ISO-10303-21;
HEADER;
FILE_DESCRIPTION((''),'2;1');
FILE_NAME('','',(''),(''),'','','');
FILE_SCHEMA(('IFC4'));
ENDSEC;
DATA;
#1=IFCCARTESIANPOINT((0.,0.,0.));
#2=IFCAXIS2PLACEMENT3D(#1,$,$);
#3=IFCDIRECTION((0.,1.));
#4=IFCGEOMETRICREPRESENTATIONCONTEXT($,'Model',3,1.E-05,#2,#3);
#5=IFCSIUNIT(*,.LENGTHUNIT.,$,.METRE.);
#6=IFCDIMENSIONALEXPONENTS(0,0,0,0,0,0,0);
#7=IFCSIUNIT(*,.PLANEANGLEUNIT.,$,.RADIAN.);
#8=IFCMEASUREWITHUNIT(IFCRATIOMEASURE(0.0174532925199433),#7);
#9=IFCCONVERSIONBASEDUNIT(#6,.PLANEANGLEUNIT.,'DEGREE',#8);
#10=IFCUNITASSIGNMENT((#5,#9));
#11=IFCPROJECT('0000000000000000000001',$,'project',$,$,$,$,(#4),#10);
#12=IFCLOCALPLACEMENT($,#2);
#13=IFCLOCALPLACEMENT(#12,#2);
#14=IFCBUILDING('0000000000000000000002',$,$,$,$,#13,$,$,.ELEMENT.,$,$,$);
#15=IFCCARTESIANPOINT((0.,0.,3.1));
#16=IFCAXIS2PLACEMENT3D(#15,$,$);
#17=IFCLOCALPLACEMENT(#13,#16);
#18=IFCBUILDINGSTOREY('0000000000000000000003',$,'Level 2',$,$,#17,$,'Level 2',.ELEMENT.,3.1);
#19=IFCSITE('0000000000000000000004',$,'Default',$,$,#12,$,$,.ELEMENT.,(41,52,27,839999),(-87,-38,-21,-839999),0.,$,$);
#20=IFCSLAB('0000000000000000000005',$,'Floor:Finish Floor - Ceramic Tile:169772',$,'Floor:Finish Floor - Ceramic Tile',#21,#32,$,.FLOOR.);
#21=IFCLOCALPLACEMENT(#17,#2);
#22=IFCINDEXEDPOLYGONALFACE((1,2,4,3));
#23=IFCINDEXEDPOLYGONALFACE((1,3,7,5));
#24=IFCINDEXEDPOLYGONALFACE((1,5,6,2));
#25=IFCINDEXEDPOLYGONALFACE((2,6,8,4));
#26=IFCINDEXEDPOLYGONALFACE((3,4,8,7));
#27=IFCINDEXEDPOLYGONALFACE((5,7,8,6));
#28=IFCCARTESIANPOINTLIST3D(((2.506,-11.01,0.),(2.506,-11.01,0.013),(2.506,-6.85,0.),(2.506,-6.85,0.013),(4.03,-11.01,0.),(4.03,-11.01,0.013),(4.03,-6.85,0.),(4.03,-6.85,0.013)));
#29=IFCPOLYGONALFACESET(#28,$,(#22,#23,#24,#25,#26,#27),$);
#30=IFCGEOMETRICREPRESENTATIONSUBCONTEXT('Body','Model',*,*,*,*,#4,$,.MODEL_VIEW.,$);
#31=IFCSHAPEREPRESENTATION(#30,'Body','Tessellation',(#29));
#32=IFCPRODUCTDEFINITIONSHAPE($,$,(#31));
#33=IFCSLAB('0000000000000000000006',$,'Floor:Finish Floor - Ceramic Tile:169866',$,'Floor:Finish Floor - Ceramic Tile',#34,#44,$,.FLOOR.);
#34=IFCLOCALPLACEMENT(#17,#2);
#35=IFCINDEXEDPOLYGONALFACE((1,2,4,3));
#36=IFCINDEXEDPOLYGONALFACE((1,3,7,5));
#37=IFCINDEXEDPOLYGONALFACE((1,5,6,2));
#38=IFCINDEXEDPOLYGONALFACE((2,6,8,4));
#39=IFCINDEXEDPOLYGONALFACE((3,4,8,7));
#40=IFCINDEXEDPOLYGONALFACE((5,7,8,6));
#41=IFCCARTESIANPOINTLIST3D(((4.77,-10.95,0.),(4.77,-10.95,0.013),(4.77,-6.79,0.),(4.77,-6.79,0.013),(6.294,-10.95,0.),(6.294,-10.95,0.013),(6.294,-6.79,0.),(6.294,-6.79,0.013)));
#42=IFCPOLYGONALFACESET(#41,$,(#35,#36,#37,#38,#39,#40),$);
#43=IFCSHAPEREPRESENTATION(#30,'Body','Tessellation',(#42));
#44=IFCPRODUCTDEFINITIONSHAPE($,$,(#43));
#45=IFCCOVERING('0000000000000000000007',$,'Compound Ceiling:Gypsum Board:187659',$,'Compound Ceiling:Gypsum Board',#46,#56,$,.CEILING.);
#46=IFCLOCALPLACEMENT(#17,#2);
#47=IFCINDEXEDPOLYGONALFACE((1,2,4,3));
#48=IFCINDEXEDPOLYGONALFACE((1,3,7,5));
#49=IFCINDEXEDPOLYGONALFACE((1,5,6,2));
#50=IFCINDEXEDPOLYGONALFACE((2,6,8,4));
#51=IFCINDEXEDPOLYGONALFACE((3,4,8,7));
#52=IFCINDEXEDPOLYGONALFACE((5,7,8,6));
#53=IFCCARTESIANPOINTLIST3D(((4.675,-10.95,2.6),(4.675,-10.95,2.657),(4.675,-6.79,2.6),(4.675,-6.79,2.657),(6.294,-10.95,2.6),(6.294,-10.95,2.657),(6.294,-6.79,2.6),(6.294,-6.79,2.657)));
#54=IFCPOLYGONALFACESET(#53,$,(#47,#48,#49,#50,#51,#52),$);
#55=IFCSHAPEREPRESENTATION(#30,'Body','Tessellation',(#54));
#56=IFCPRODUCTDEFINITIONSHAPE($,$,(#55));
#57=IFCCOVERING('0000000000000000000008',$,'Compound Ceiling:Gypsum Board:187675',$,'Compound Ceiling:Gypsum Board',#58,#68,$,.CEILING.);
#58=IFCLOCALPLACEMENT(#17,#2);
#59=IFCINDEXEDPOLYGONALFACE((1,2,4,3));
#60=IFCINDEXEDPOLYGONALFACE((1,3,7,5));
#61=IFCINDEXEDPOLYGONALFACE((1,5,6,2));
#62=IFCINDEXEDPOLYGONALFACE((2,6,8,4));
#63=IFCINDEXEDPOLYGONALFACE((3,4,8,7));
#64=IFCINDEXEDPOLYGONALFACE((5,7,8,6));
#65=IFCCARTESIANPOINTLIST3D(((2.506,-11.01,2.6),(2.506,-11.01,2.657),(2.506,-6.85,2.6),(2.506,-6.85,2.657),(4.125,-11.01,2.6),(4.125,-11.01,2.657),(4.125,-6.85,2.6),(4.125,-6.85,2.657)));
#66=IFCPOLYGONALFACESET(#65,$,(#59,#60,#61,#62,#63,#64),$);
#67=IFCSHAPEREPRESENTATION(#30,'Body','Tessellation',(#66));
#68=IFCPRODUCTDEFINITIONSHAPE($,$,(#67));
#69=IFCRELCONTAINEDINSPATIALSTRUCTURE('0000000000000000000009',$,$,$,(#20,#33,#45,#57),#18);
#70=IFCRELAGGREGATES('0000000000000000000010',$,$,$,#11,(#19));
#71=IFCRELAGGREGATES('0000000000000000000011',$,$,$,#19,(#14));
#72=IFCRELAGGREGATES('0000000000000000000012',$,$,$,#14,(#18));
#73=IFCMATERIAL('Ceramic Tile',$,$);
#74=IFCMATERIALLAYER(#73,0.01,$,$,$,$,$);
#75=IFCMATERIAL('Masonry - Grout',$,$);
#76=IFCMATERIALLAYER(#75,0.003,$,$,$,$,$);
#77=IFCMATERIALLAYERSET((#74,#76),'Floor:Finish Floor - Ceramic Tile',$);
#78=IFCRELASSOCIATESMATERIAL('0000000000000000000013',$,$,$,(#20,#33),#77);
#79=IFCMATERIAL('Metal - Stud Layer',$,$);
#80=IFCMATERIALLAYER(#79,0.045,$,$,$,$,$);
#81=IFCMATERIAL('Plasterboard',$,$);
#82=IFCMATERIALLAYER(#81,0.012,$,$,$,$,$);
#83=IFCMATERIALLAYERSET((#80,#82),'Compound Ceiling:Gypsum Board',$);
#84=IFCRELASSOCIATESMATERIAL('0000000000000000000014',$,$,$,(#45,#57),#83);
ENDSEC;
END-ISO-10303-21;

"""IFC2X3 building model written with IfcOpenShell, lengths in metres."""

from ifc_helpers import new_model, entity, si_unit, converted_unit, direction, frame, frame_2d, origin, place, context, subcontext, project, spatial, rectangle, extrude, material, layer, layer_set, layer_usage, element, save


model = new_model("IFC2X3")

# Units and contexts
model_context = context("Model", 3, precision=1e-05, world=origin(), true_north=direction((0.0, 1.0)))
body_context = subcontext(model_context, "Body", "Model", "MODEL_VIEW")
ifc_project = project(units=[si_unit("LENGTHUNIT", "METRE"), converted_unit("PLANEANGLEUNIT", "DEGREE", entity("IfcRatioMeasure", 0.0174532925199433), si_unit("PLANEANGLEUNIT", "RADIAN"), dimensions=[0, 0, 0, 0, 0, 0, 0])], contexts=[model_context])

# Site, building, storey
site_placement = place(None, origin())
site = spatial("IfcSite", under=ifc_project, at=site_placement, Name="Default", CompositionType="ELEMENT", RefLatitude=(41, 52, 27, 839999), RefLongitude=(-87, -38, -21, -839999), RefElevation=0.0)
building_placement = place(site_placement, origin())
building = spatial("IfcBuilding", under=site, at=building_placement, CompositionType="ELEMENT")
storey_placement = place(building_placement, frame((0.0, 0.0, 3.1)))
storey = spatial("IfcBuildingStorey", under=building, at=storey_placement, Name="Level 2", LongName="Level 2", CompositionType="ELEMENT", Elevation=3.1)

# Slabs
ifc_material_1 = material(Name="Ceramic Tile")
ifc_layer_1 = layer(ifc_material_1, 0.01)
ifc_material_2 = material(Name="Masonry - Grout")
ifc_layer_2 = layer(ifc_material_2, 0.003)
ifc_layer_set_1 = layer_set([ifc_layer_1, ifc_layer_2], Name="Floor:Finish Floor - Ceramic Tile")
ifc_layer_usage_1 = layer_usage(ifc_layer_set_1, "AXIS3", "POSITIVE", 0.0)
slab_1_placement = place(storey_placement, origin())
element("IfcSlab", 1, at=slab_1_placement, inside=storey, material=ifc_layer_usage_1, Name="Floor:Finish Floor - Ceramic Tile:169772", ObjectType="Floor:Finish Floor - Ceramic Tile", PredefinedType="FLOOR", context=body_context, shape_type="SweptSolid", body=[
    extrude(rectangle(XDim=4.16, YDim=1.524, at=frame_2d((0.0, 0.0), x_axis=(1.0, 0.0))), frame((3.268, -8.93, 0.013), z_axis=(0.0, 0.0, -1.0), x_axis=(0.0, 1.0, 0.0)), (0.0, 0.0, 1.0), 0.013),
])
ifc_layer_usage_2 = layer_usage(ifc_layer_set_1, "AXIS3", "POSITIVE", 0.0)
slab_2_placement = place(storey_placement, origin())
element("IfcSlab", 2, at=slab_2_placement, inside=storey, material=ifc_layer_usage_2, Name="Floor:Finish Floor - Ceramic Tile:169866", ObjectType="Floor:Finish Floor - Ceramic Tile", PredefinedType="FLOOR", context=body_context, shape_type="SweptSolid", body=[
    extrude(rectangle(XDim=4.16, YDim=1.524, at=frame_2d((0.0, 0.0), x_axis=(1.0, 0.0))), frame((5.532, -8.87, 0.013), z_axis=(0.0, 0.0, -1.0), x_axis=(0.0, 1.0, 0.0)), (0.0, 0.0, 1.0), 0.013),
])

# Shared definitions
ifc_material_3 = material(Name="Metal - Stud Layer")
ifc_material_4 = material(Name="Plasterboard")

# Coverings
ifc_layer_3 = layer(ifc_material_3, 0.045)
ifc_layer_4 = layer(ifc_material_4, 0.012)
ifc_layer_set_2 = layer_set([ifc_layer_3, ifc_layer_4], Name="Compound Ceiling:Gypsum Board")
ifc_layer_usage_3 = layer_usage(ifc_layer_set_2, "AXIS3", "POSITIVE", 0.0)
covering_1_placement = place(storey_placement, origin())
element("IfcCovering", 3, at=covering_1_placement, inside=storey, material=ifc_layer_usage_3, Name="Compound Ceiling:Gypsum Board:187659", ObjectType="Compound Ceiling:Gypsum Board", PredefinedType="CEILING", context=body_context, shape_type="SweptSolid", body=[
    extrude(rectangle(XDim=1.619, YDim=4.16, at=frame_2d((0.0, 0.0), x_axis=(1.0, 0.0))), frame((5.4845, -8.87, 2.6)), (0.0, 0.0, 1.0), 0.057),
])
ifc_layer_usage_4 = layer_usage(ifc_layer_set_2, "AXIS3", "POSITIVE", 0.0)
covering_2_placement = place(storey_placement, origin())
element("IfcCovering", 4, at=covering_2_placement, inside=storey, material=ifc_layer_usage_4, Name="Compound Ceiling:Gypsum Board:187675", ObjectType="Compound Ceiling:Gypsum Board", PredefinedType="CEILING", context=body_context, shape_type="SweptSolid", body=[
    extrude(rectangle(XDim=1.619, YDim=4.16, at=frame_2d((0.0, 0.0), x_axis=(1.0, 0.0))), frame((3.3155, -8.93, 2.6), z_axis=(0.0, 0.0, 1.0), x_axis=(-1.0, 0.0, 0.0)), (0.0, 0.0, 1.0), 0.057),
])

save(model, "model.ifc")
